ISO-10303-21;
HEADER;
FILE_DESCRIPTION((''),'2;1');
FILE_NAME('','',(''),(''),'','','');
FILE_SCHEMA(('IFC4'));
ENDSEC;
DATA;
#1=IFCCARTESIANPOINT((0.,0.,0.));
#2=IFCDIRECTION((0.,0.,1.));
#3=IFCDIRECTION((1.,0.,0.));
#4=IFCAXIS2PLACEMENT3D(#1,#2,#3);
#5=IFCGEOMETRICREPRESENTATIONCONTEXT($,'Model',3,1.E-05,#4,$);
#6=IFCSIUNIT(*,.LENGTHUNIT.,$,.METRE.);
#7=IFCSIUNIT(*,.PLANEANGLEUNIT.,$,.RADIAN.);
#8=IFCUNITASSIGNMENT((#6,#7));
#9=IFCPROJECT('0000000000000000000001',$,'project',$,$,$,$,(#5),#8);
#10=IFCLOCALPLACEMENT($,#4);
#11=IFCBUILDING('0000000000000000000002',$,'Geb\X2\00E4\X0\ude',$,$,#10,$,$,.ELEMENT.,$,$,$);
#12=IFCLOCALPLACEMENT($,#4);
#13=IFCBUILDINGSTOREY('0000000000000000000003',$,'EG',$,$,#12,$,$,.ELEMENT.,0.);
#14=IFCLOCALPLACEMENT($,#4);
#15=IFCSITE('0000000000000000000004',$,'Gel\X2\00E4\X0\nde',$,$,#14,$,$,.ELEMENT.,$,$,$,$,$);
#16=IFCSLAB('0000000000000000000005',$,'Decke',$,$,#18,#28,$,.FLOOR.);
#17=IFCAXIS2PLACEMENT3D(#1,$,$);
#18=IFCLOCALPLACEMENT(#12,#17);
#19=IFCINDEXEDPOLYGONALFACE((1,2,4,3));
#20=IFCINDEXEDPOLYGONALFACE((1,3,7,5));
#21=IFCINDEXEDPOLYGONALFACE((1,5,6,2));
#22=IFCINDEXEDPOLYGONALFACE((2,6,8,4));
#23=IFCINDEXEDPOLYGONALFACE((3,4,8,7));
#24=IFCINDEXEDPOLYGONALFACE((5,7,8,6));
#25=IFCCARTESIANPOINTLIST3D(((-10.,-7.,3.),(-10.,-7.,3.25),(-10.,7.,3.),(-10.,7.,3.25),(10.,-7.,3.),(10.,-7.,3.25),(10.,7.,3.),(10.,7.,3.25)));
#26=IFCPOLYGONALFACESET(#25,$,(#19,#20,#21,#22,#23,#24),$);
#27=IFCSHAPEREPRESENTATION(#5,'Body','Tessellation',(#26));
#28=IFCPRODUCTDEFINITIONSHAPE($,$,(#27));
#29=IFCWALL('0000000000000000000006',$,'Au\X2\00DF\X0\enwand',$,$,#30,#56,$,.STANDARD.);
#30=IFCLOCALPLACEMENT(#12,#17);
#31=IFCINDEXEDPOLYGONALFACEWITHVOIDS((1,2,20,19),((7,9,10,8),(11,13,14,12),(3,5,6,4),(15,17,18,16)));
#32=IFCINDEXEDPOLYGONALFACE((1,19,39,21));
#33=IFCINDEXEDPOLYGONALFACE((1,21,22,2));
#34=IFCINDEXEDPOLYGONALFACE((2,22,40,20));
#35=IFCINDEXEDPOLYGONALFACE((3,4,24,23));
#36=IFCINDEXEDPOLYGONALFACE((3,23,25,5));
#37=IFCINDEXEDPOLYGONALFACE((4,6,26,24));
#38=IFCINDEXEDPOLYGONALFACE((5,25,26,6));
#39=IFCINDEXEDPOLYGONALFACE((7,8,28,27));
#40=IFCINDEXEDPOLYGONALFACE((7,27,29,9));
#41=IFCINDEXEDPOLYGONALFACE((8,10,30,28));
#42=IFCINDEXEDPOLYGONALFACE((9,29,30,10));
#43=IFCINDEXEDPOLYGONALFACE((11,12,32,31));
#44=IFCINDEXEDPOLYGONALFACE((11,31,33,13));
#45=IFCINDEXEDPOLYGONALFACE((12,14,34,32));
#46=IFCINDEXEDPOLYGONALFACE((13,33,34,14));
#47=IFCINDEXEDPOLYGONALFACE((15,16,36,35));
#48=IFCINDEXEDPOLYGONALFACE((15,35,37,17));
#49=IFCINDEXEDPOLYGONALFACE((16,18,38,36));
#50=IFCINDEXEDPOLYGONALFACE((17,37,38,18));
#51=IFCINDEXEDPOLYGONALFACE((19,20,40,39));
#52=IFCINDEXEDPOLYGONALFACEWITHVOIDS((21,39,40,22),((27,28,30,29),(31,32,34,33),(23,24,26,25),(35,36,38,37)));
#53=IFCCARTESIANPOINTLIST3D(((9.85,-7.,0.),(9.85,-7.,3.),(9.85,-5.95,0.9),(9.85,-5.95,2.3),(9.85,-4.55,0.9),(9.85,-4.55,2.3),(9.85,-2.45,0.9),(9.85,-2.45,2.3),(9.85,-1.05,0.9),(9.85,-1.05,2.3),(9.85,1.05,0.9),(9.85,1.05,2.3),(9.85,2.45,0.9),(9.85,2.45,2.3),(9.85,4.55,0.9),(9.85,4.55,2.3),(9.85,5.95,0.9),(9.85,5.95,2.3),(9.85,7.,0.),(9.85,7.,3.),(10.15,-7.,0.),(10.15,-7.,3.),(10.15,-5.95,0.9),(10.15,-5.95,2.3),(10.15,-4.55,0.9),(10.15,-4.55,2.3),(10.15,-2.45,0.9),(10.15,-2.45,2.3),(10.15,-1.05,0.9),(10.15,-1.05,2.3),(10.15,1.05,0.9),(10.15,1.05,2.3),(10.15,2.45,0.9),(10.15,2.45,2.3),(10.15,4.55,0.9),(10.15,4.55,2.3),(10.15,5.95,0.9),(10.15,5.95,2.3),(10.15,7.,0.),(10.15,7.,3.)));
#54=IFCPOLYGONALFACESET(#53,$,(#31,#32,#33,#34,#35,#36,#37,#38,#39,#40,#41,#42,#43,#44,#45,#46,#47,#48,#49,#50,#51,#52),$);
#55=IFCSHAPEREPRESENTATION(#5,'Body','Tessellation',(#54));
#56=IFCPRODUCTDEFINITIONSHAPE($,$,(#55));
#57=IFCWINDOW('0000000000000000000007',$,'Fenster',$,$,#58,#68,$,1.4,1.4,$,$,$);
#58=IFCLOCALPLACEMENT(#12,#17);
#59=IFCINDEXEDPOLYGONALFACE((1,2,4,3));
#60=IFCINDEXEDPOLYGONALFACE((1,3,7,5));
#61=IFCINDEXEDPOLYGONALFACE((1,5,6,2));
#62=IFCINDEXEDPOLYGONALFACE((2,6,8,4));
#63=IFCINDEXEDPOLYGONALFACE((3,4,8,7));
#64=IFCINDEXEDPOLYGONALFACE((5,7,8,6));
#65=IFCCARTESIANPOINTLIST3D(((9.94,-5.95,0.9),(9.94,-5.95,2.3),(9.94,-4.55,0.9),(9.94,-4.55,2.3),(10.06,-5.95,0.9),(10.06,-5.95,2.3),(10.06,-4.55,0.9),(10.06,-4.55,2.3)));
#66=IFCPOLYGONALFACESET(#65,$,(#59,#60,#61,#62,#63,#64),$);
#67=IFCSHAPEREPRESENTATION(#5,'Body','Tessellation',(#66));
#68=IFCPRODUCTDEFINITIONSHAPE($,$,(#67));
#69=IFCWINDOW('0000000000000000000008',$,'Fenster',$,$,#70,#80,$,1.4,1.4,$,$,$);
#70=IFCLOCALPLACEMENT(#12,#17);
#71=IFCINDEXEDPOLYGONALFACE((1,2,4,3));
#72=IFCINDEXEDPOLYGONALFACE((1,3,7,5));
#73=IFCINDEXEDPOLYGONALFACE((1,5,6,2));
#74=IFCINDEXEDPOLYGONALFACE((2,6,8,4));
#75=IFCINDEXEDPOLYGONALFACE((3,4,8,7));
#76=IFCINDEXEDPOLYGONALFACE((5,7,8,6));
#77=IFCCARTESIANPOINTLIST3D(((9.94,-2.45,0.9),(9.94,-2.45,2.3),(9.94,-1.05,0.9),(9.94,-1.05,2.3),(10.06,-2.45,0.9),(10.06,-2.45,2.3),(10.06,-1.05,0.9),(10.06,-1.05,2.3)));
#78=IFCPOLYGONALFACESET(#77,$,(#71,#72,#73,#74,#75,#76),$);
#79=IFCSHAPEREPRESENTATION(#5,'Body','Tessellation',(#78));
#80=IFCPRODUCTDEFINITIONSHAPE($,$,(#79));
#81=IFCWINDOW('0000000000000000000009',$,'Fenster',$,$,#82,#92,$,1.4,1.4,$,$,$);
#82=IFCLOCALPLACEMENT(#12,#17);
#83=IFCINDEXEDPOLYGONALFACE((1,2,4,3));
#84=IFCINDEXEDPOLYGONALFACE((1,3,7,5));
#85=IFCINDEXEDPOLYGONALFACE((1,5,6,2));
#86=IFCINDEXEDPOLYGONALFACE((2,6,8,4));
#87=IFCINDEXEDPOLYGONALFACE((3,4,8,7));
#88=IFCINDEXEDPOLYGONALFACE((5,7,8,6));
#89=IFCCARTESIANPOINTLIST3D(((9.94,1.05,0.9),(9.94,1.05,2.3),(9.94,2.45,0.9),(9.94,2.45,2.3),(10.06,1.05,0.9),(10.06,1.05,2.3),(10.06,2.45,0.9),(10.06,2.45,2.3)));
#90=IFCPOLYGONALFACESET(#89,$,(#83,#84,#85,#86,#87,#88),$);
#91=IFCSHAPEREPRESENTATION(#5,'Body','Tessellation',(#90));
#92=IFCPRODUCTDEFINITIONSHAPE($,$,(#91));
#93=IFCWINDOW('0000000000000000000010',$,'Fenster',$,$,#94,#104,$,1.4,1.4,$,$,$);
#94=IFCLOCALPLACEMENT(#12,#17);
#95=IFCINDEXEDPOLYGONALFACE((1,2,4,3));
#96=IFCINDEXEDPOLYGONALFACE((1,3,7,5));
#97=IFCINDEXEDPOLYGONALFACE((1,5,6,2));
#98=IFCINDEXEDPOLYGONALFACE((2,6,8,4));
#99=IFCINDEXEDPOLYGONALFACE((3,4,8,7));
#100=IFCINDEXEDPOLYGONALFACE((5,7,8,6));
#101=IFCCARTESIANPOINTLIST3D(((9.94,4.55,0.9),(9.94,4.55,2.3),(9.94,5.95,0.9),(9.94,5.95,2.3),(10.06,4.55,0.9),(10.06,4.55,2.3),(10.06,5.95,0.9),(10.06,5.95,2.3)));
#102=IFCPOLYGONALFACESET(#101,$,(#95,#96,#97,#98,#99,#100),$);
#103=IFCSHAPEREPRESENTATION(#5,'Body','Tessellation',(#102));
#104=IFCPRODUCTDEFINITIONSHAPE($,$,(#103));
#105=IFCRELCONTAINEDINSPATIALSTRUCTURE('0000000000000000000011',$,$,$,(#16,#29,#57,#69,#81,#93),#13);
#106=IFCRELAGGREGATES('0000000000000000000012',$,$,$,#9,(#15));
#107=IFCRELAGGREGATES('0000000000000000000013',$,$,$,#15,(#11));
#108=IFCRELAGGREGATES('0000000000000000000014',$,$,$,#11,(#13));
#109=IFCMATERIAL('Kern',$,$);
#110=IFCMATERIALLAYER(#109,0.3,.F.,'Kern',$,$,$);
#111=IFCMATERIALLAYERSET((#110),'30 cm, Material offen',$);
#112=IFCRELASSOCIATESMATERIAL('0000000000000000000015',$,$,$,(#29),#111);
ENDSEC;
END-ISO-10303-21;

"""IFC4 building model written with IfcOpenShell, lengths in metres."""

from ifc_helpers import new_model, si_unit, frame, origin_with_axes, origin_2d, place, context, project, spatial, polyline, rectangle, outline, extrude, material, layer, layer_set, element, fill, save


model = new_model("IFC4")

# Units and contexts
model_context = context("Model", 3, precision=1e-05, world=origin_with_axes())
ifc_project = project(units=[si_unit("LENGTHUNIT", "METRE"), si_unit("PLANEANGLEUNIT", "RADIAN")], contexts=[model_context])

# Site, building, storey
site_placement = place(None, origin_with_axes())
site = spatial("IfcSite", under=ifc_project, at=site_placement, Name="Gelände", CompositionType="ELEMENT")
building_placement = place(None, origin_with_axes())
building = spatial("IfcBuilding", under=site, at=building_placement, Name="Gebäude", CompositionType="ELEMENT")
storey_placement = place(None, origin_with_axes())
storey = spatial("IfcBuildingStorey", under=building, at=storey_placement, Name="EG", CompositionType="ELEMENT", Elevation=0.0)

# Slab
slab_placement = place(None, frame((0.0, 0.0, 3.0), z_axis=(0.0, 0.0, 1.0), x_axis=(1.0, 0.0, 0.0)))
element("IfcSlab", 1, at=slab_placement, inside=storey, Name="Decke", PredefinedType="FLOOR", context=model_context, shape_type="SweptSolid", body=[
    extrude(outline(polyline([(-10.0, -7.0), (10.0, -7.0), (10.0, 7.0), (-10.0, 7.0), (-10.0, -7.0)])), origin_with_axes(), (0.0, 0.0, 1.0), 0.25),
])

# Wall, openings, windows
ifc_material = material(Name="Kern")
ifc_layer = layer(ifc_material, 0.3, ventilated=False, Name="Kern")
ifc_layer_set = layer_set([ifc_layer], Name="30 cm, Material offen")
wall_1_placement = place(None, frame((10.0, 0.0, 0.0), z_axis=(0.0, 0.0, 1.0), x_axis=(0.0, 1.0, 0.0)))
wall_1 = element("IfcWall", 2, at=wall_1_placement, inside=storey, material=ifc_layer_set, Name="Außenwand", PredefinedType="STANDARD", context=model_context, shape_type="SweptSolid", body=[
    extrude(rectangle(XDim=14.0, YDim=0.3, at=origin_2d()), origin_with_axes(), (0.0, 0.0, 1.0), 3.0),
])
opening_1_placement = place(wall_1_placement, frame((-5.25, 0.0, 0.9), z_axis=(0.0, 0.0, 1.0), x_axis=(1.0, 0.0, 0.0)))
opening_1 = element("IfcOpeningElement", 3, at=opening_1_placement, cuts=wall_1, PredefinedType="OPENING", context=model_context, shape_type="SweptSolid", body=[
    extrude(rectangle(XDim=1.4, YDim=0.34, at=origin_2d()), origin_with_axes(), (0.0, 0.0, 1.0), 1.4),
])
opening_2_placement = place(wall_1_placement, frame((-1.75, 0.0, 0.9), z_axis=(0.0, 0.0, 1.0), x_axis=(1.0, 0.0, 0.0)))
opening_2 = element("IfcOpeningElement", 4, at=opening_2_placement, cuts=wall_1, PredefinedType="OPENING", context=model_context, shape_type="SweptSolid", body=[
    extrude(rectangle(XDim=1.4, YDim=0.34, at=origin_2d()), origin_with_axes(), (0.0, 0.0, 1.0), 1.4),
])
opening_3_placement = place(wall_1_placement, frame((1.75, 0.0, 0.9), z_axis=(0.0, 0.0, 1.0), x_axis=(1.0, 0.0, 0.0)))
opening_3 = element("IfcOpeningElement", 5, at=opening_3_placement, cuts=wall_1, PredefinedType="OPENING", context=model_context, shape_type="SweptSolid", body=[
    extrude(rectangle(XDim=1.4, YDim=0.34, at=origin_2d()), origin_with_axes(), (0.0, 0.0, 1.0), 1.4),
])
opening_4_placement = place(wall_1_placement, frame((5.25, 0.0, 0.9), z_axis=(0.0, 0.0, 1.0), x_axis=(1.0, 0.0, 0.0)))
opening_4 = element("IfcOpeningElement", 6, at=opening_4_placement, cuts=wall_1, PredefinedType="OPENING", context=model_context, shape_type="SweptSolid", body=[
    extrude(rectangle(XDim=1.4, YDim=0.34, at=origin_2d()), origin_with_axes(), (0.0, 0.0, 1.0), 1.4),
])
window_1_placement = place(opening_1_placement, origin_with_axes())
window_1 = element("IfcWindow", 7, at=window_1_placement, inside=storey, Name="Fenster", OverallHeight=1.4, OverallWidth=1.4, context=model_context, shape_type="SweptSolid", body=[
    extrude(rectangle(XDim=1.4, YDim=0.12, at=origin_2d()), origin_with_axes(), (0.0, 0.0, 1.0), 1.4),
])
fill(opening_1, window_1)
window_2_placement = place(opening_2_placement, origin_with_axes())
window_2 = element("IfcWindow", 8, at=window_2_placement, inside=storey, Name="Fenster", OverallHeight=1.4, OverallWidth=1.4, context=model_context, shape_type="SweptSolid", body=[
    extrude(rectangle(XDim=1.4, YDim=0.12, at=origin_2d()), origin_with_axes(), (0.0, 0.0, 1.0), 1.4),
])
fill(opening_2, window_2)
window_3_placement = place(opening_3_placement, origin_with_axes())
window_3 = element("IfcWindow", 9, at=window_3_placement, inside=storey, Name="Fenster", OverallHeight=1.4, OverallWidth=1.4, context=model_context, shape_type="SweptSolid", body=[
    extrude(rectangle(XDim=1.4, YDim=0.12, at=origin_2d()), origin_with_axes(), (0.0, 0.0, 1.0), 1.4),
])
fill(opening_3, window_3)
window_4_placement = place(opening_4_placement, origin_with_axes())
window_4 = element("IfcWindow", 10, at=window_4_placement, inside=storey, Name="Fenster", OverallHeight=1.4, OverallWidth=1.4, context=model_context, shape_type="SweptSolid", body=[
    extrude(rectangle(XDim=1.4, YDim=0.12, at=origin_2d()), origin_with_axes(), (0.0, 0.0, 1.0), 1.4),
])
fill(opening_4, window_4)

save(model, "model.ifc")
